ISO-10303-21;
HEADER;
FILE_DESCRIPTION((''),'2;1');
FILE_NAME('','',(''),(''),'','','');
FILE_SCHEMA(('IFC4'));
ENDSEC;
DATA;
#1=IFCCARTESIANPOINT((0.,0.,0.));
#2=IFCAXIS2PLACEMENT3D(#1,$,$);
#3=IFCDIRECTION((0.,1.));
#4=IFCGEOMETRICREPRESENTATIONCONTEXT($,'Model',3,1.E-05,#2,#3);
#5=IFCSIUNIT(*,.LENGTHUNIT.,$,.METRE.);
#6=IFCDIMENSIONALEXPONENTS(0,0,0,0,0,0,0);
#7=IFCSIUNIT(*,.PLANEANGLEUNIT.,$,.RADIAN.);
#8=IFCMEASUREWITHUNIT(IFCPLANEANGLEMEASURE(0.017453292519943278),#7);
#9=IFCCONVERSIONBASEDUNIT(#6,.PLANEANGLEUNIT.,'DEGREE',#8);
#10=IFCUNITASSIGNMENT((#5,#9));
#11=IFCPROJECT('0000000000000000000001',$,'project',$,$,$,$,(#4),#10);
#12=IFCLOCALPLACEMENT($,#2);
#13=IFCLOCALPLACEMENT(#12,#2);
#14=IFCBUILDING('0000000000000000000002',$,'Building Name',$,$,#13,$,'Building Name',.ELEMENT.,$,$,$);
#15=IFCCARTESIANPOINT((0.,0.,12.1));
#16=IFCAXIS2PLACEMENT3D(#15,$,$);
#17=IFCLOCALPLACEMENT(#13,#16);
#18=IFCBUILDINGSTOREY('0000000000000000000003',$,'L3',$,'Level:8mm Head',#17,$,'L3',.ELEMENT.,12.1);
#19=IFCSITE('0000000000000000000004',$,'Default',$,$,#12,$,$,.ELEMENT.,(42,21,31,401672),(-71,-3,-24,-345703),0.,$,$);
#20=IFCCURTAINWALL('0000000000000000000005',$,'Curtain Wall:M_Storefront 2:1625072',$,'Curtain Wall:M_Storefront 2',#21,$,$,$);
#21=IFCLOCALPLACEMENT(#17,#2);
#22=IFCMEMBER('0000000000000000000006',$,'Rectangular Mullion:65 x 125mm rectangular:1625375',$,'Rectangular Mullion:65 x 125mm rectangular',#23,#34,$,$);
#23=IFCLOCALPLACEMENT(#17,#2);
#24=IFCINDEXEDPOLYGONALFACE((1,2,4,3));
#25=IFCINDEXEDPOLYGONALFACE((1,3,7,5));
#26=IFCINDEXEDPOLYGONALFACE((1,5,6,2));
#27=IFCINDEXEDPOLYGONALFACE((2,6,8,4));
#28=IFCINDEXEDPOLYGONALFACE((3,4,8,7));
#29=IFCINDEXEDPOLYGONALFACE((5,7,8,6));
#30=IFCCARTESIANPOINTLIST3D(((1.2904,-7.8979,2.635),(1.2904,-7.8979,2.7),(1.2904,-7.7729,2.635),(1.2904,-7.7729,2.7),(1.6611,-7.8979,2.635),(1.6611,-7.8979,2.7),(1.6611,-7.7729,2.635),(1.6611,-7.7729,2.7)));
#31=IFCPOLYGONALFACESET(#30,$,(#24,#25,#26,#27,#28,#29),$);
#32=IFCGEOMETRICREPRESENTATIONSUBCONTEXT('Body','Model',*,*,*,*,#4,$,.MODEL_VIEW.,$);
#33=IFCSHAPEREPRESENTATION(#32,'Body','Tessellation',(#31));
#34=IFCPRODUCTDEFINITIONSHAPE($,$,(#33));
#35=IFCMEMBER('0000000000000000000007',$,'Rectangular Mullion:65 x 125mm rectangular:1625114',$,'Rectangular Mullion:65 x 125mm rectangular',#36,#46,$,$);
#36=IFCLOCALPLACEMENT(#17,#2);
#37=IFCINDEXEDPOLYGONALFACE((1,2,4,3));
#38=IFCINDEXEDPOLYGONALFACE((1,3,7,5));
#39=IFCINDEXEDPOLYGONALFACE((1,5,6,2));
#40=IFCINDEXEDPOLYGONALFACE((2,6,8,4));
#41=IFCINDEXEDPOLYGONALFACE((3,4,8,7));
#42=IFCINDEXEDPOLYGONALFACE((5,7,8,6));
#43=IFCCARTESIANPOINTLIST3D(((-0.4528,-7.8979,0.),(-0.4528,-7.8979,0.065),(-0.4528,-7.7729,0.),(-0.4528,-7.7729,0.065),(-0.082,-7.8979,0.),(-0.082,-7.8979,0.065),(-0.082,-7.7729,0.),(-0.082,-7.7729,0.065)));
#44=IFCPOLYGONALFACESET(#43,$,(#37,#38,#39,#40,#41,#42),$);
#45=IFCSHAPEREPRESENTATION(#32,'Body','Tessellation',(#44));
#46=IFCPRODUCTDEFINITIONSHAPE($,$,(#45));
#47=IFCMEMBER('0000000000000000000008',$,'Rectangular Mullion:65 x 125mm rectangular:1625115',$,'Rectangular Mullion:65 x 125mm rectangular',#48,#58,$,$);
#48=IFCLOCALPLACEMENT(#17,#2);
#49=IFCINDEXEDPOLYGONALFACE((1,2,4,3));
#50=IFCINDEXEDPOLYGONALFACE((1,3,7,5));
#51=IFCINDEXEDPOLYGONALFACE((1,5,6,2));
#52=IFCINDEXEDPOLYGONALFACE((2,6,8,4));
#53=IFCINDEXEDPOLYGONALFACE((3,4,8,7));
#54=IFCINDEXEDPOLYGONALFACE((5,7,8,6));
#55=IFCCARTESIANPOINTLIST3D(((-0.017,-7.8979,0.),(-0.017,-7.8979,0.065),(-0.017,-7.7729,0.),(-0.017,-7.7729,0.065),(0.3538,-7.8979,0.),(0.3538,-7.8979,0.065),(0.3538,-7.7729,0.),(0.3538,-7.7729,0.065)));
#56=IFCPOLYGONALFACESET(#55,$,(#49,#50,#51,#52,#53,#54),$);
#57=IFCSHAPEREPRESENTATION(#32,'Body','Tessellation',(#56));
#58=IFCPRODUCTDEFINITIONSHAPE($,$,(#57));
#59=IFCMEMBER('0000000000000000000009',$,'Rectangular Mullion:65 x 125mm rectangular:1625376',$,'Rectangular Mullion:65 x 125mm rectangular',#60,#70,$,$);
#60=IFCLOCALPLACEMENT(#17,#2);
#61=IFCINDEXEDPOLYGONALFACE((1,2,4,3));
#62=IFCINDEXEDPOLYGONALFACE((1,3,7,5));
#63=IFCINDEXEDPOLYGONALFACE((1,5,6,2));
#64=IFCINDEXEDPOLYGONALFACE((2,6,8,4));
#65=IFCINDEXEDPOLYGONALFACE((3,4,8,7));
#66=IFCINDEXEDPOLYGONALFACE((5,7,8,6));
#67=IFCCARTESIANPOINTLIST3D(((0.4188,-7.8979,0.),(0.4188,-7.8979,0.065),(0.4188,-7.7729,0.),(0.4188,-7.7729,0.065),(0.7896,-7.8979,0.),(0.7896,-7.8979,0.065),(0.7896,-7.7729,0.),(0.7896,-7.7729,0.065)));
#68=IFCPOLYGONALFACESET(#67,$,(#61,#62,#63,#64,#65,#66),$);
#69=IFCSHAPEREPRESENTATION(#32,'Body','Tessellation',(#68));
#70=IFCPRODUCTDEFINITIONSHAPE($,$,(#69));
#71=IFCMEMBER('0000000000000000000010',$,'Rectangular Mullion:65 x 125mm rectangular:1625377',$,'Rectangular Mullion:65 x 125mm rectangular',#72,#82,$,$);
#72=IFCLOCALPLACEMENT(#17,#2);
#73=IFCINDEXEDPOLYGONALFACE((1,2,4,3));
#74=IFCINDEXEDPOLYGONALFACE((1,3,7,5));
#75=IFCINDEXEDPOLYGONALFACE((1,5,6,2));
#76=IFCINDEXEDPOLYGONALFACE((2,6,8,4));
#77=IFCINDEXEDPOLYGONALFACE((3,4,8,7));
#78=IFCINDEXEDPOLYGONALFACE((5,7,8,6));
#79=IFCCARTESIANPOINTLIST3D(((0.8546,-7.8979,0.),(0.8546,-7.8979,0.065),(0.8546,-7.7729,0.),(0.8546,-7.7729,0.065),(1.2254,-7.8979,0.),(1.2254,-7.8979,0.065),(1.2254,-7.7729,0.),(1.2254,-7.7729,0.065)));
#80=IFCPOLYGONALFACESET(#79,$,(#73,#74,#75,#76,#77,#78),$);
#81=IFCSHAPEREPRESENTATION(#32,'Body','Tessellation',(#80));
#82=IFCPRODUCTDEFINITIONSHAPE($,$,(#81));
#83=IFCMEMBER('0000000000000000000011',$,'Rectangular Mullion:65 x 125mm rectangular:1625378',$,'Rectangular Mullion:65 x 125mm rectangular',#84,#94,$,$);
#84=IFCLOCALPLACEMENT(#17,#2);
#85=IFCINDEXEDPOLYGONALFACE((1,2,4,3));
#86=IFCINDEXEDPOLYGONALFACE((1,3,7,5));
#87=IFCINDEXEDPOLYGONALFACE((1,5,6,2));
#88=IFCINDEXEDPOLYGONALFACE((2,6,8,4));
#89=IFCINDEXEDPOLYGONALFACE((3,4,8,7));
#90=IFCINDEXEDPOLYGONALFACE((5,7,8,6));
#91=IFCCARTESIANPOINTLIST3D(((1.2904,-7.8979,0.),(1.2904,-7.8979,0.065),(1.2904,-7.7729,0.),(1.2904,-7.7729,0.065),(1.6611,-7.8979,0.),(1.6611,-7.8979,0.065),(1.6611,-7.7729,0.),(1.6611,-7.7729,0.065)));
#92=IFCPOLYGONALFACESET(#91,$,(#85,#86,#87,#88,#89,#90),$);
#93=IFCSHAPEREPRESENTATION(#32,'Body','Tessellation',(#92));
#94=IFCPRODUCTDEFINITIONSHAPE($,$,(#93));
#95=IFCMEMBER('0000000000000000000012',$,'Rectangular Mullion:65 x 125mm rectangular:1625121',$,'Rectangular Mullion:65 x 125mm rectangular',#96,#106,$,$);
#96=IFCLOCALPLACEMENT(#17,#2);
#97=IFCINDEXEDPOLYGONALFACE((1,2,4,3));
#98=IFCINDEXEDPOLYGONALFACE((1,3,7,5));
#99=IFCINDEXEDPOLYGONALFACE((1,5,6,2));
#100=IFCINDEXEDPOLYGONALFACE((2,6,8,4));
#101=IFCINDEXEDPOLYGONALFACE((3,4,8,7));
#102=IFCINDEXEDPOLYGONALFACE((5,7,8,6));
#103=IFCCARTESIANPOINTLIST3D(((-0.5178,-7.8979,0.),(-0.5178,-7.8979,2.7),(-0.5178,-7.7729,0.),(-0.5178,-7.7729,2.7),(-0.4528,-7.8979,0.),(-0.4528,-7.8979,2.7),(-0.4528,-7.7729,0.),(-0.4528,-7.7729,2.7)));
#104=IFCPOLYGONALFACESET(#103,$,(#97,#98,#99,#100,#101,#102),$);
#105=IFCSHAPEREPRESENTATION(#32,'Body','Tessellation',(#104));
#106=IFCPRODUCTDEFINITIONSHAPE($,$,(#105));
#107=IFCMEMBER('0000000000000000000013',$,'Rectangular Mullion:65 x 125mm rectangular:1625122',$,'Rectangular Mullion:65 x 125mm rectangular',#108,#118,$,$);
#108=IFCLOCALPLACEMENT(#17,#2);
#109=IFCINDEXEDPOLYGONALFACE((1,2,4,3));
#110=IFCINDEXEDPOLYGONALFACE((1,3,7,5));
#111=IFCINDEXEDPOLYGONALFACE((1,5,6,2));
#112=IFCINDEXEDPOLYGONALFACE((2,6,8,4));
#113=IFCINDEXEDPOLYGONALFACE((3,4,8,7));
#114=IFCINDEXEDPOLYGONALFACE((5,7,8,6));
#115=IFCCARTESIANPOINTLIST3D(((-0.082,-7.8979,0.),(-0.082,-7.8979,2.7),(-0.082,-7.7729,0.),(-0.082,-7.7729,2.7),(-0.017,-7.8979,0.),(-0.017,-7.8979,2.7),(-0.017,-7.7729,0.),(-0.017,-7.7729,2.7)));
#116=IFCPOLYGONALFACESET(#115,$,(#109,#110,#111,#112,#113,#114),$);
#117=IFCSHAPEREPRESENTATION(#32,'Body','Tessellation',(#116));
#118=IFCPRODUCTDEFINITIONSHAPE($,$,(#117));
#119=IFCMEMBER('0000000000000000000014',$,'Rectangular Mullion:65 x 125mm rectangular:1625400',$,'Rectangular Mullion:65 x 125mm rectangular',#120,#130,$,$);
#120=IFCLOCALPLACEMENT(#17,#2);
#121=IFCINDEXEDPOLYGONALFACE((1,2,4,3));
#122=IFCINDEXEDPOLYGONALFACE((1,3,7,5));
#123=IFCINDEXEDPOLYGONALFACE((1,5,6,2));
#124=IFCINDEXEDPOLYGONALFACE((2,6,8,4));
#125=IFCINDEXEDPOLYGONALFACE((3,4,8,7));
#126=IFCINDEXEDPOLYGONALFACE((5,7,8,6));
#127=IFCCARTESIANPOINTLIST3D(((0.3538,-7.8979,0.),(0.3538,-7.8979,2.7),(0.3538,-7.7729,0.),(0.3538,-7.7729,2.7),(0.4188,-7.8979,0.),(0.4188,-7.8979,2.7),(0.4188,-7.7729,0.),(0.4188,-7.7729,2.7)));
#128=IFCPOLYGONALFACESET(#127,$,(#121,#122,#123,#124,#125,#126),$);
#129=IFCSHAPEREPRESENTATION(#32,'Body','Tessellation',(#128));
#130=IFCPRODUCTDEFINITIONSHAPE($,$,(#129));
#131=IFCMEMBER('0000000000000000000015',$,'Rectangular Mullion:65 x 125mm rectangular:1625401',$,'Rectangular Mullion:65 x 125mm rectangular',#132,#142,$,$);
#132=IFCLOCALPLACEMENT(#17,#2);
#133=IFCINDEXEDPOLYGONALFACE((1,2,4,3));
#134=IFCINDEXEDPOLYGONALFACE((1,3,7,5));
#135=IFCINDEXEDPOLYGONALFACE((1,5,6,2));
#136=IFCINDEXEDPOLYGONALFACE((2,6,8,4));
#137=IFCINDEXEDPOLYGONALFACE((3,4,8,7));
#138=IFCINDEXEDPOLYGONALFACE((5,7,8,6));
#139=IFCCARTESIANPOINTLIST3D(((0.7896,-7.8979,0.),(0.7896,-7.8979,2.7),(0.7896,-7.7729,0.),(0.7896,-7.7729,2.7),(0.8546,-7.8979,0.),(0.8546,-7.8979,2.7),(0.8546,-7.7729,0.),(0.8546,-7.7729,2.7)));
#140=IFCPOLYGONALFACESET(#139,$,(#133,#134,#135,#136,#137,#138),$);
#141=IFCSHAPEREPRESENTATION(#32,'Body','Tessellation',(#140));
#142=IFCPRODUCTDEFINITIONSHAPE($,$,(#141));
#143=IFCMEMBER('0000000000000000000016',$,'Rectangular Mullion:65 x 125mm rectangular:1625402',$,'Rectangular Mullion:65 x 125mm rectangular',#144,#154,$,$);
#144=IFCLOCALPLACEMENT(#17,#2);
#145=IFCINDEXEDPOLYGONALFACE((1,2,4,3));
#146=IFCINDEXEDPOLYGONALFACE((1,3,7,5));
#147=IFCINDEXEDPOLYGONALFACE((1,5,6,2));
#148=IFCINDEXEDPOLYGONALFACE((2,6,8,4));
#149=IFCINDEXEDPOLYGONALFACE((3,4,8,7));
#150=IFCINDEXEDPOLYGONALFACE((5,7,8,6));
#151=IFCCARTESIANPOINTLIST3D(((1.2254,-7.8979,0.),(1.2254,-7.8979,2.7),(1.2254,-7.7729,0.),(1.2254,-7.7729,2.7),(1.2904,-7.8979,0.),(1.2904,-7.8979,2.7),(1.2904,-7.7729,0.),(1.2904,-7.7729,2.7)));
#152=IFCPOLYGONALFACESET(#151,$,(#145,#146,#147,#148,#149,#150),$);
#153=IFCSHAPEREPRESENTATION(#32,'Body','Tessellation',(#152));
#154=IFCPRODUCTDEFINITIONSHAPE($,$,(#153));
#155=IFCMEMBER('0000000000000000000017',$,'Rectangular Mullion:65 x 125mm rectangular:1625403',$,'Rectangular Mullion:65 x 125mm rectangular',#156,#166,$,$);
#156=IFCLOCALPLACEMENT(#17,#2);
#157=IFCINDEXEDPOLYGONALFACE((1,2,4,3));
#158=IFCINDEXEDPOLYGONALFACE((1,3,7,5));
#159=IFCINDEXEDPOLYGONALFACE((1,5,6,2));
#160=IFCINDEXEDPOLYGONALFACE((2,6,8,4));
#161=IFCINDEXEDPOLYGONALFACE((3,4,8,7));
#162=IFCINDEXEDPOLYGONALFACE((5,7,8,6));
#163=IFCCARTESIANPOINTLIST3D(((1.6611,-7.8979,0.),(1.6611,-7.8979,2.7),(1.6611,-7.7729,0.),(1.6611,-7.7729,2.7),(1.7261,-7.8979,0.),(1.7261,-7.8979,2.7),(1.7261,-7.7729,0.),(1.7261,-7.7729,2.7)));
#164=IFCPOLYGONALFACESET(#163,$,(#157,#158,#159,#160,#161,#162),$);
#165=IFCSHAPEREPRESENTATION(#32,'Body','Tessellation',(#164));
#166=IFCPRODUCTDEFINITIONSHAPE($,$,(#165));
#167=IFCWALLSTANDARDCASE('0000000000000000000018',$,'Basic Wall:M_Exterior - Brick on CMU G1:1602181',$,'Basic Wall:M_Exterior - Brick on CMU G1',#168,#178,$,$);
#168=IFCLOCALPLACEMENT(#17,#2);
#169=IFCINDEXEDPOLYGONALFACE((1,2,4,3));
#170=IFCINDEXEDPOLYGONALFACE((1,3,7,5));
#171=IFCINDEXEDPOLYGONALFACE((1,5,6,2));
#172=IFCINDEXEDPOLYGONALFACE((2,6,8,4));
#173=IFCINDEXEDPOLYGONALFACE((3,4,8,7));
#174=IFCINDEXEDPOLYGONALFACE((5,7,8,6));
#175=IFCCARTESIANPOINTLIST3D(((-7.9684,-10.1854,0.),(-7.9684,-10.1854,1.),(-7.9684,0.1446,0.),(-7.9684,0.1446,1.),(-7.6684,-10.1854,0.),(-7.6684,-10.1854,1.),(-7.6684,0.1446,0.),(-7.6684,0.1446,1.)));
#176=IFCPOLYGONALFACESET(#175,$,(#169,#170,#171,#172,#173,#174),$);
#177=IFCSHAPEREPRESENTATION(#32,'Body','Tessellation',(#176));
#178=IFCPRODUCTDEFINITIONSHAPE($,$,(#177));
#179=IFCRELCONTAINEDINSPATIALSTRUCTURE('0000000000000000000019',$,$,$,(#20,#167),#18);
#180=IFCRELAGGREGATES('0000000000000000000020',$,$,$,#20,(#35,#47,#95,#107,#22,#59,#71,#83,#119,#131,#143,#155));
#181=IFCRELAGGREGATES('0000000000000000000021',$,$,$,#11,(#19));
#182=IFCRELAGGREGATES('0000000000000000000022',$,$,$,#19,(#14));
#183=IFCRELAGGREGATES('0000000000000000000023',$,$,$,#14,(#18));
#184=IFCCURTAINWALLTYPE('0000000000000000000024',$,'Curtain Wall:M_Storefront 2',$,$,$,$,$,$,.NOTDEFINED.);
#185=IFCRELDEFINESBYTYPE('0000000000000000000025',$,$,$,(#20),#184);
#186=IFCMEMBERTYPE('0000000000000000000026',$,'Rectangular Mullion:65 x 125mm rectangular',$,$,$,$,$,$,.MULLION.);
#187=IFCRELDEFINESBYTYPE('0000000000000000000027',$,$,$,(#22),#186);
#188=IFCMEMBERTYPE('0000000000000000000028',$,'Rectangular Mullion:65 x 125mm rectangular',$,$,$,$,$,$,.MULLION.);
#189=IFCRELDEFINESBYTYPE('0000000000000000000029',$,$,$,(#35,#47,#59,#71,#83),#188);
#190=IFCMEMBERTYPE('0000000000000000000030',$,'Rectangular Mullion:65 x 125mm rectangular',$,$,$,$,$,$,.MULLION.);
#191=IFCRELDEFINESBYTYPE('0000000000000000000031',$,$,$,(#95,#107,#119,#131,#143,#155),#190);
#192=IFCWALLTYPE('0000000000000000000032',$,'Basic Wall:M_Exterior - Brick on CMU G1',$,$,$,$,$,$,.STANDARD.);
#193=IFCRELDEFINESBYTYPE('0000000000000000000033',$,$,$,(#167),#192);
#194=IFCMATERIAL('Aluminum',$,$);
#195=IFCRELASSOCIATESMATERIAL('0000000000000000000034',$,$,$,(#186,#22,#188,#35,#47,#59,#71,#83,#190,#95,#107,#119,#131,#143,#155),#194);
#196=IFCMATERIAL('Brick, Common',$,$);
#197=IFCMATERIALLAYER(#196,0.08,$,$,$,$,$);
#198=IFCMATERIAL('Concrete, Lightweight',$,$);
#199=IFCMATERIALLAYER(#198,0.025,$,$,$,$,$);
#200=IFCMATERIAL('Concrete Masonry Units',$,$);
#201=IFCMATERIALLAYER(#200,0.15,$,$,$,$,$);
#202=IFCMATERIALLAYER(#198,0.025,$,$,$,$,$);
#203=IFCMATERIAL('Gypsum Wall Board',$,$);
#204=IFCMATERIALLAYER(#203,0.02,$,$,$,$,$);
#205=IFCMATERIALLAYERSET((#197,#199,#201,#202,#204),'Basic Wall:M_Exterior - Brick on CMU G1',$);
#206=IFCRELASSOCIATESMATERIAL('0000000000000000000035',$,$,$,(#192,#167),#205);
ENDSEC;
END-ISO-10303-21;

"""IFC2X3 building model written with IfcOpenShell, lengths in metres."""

from ifc_helpers import new_model, entity, si_unit, converted_unit, direction, frame, frame_2d, origin, origin_2d_with_axis, place, context, subcontext, project, spatial, rectangle, extrude, source, transform, mapped, material, layer, layer_set, layer_usage, type_object, type_shapes, element, aggregate, save


model = new_model("IFC2X3")

# Units and contexts
model_context = context("Model", 3, precision=1e-05, world=origin(), true_north=direction((0.0, 1.0)))
body_context = subcontext(model_context, "Body", "Model", "MODEL_VIEW")
ifc_project = project(units=[si_unit("LENGTHUNIT", "METRE"), converted_unit("PLANEANGLEUNIT", "DEGREE", entity("IfcPlaneAngleMeasure", 0.017453292519943278), si_unit("PLANEANGLEUNIT", "RADIAN"), dimensions=[0, 0, 0, 0, 0, 0, 0])], contexts=[model_context])

# Site, building, storey
site_placement = place(None, origin())
site = spatial("IfcSite", under=ifc_project, at=site_placement, Name="Default", CompositionType="ELEMENT", RefLatitude=(42, 21, 31, 401672), RefLongitude=(-71, -3, -24, -345703), RefElevation=0.0)
building_placement = place(site_placement, origin())
building = spatial("IfcBuilding", under=site, at=building_placement, Name="Building Name", LongName="Building Name", CompositionType="ELEMENT")
storey_placement = place(building_placement, frame((0.0, 0.0, 12.1)))
storey = spatial("IfcBuildingStorey", under=building, at=storey_placement, Name="L3", ObjectType="Level:8mm Head", LongName="L3", CompositionType="ELEMENT", Elevation=12.1)

# Curtain wall, members
ifc_material_1 = material(Name="Aluminum")
curtain_wall_type_1 = type_object("IfcCurtainWallType", Name="Curtain Wall:M_Storefront 2", PredefinedType="NOTDEFINED")
curtain_wall_1_placement = place(storey_placement, frame((0.0, 0.0, -12.1)))
curtain_wall_1 = element("IfcCurtainWall", 1, at=curtain_wall_1_placement, inside=storey, type_object=curtain_wall_type_1, Name="Curtain Wall:M_Storefront 2:1625072", ObjectType="Curtain Wall:M_Storefront 2")
member_type_1 = type_object("IfcMemberType", Name="Rectangular Mullion:65 x 125mm rectangular", PredefinedType="MULLION", material=ifc_material_1)
shared_shape_1 = source(origin(), body_context, "Body", "SweptSolid", [
    extrude(rectangle(XDim=0.065, YDim=0.125, at=origin_2d_with_axis()), frame((-0.0325, 0.0, -0.3708), z_axis=(0.0, 0.0, 1.0), x_axis=(-1.0, 0.0, 0.0)), (0.0, 0.0, 1.0), 0.3708),
])
type_shapes(member_type_1, [shared_shape_1])
member_1_placement = place(curtain_wall_1_placement, frame((1.6611, -7.8354, 14.8), z_axis=(1.0, 0.0, 0.0), x_axis=(0.0, 0.0, 1.0)))
member_1 = element("IfcMember", 2, at=member_1_placement, type_object=member_type_1, material=ifc_material_1, Name="Rectangular Mullion:65 x 125mm rectangular:1625375", ObjectType="Rectangular Mullion:65 x 125mm rectangular", context=body_context, shape_type="MappedRepresentation", body=[
    mapped(shared_shape_1, transform((0.0, 0.0, 0.0), scale=1.0)),
])
member_type_2 = type_object("IfcMemberType", Name="Rectangular Mullion:65 x 125mm rectangular", PredefinedType="MULLION", material=ifc_material_1)
shared_shape_2 = source(origin(), body_context, "Body", "SweptSolid", [
    extrude(rectangle(XDim=0.065, YDim=0.125, at=origin_2d_with_axis()), frame((-0.0325, 0.0, -0.3708), z_axis=(0.0, 0.0, 1.0), x_axis=(-1.0, 0.0, 0.0)), (0.0, 0.0, 1.0), 0.3708),
])
type_shapes(member_type_2, [shared_shape_2])
member_2_placement = place(curtain_wall_1_placement, frame((-0.4528, -7.8354, 12.1), z_axis=(-1.0, 0.0, 0.0), x_axis=(0.0, 0.0, -1.0)))
member_2 = element("IfcMember", 3, at=member_2_placement, type_object=member_type_2, material=ifc_material_1, Name="Rectangular Mullion:65 x 125mm rectangular:1625114", ObjectType="Rectangular Mullion:65 x 125mm rectangular", context=body_context, shape_type="MappedRepresentation", body=[
    mapped(shared_shape_2, transform((0.0, 0.0, 0.0), scale=1.0)),
])
member_3_placement = place(curtain_wall_1_placement, frame((-0.017, -7.8354, 12.1), z_axis=(-1.0, 0.0, 0.0), x_axis=(0.0, 0.0, -1.0)))
member_3 = element("IfcMember", 4, at=member_3_placement, type_object=member_type_2, material=ifc_material_1, Name="Rectangular Mullion:65 x 125mm rectangular:1625115", ObjectType="Rectangular Mullion:65 x 125mm rectangular", context=body_context, shape_type="MappedRepresentation", body=[
    mapped(shared_shape_2, transform((0.0, 0.0, 0.0), scale=1.0)),
])
member_4_placement = place(curtain_wall_1_placement, frame((0.4188, -7.8354, 12.1), z_axis=(-1.0, 0.0, 0.0), x_axis=(0.0, 0.0, -1.0)))
member_4 = element("IfcMember", 5, at=member_4_placement, type_object=member_type_2, material=ifc_material_1, Name="Rectangular Mullion:65 x 125mm rectangular:1625376", ObjectType="Rectangular Mullion:65 x 125mm rectangular", context=body_context, shape_type="MappedRepresentation", body=[
    mapped(shared_shape_2, transform((0.0, 0.0, 0.0), scale=1.0)),
])
member_5_placement = place(curtain_wall_1_placement, frame((0.8546, -7.8354, 12.1), z_axis=(-1.0, 0.0, 0.0), x_axis=(0.0, 0.0, -1.0)))
member_5 = element("IfcMember", 6, at=member_5_placement, type_object=member_type_2, material=ifc_material_1, Name="Rectangular Mullion:65 x 125mm rectangular:1625377", ObjectType="Rectangular Mullion:65 x 125mm rectangular", context=body_context, shape_type="MappedRepresentation", body=[
    mapped(shared_shape_2, transform((0.0, 0.0, 0.0), scale=1.0)),
])
member_6_placement = place(curtain_wall_1_placement, frame((1.2904, -7.8354, 12.1), z_axis=(-1.0, 0.0, 0.0), x_axis=(0.0, 0.0, -1.0)))
member_6 = element("IfcMember", 7, at=member_6_placement, type_object=member_type_2, material=ifc_material_1, Name="Rectangular Mullion:65 x 125mm rectangular:1625378", ObjectType="Rectangular Mullion:65 x 125mm rectangular", context=body_context, shape_type="MappedRepresentation", body=[
    mapped(shared_shape_2, transform((0.0, 0.0, 0.0), scale=1.0)),
])
member_type_3 = type_object("IfcMemberType", Name="Rectangular Mullion:65 x 125mm rectangular", PredefinedType="MULLION", material=ifc_material_1)
shared_shape_3 = source(origin(), body_context, "Body", "SweptSolid", [
    extrude(rectangle(XDim=0.065, YDim=0.125, at=origin_2d_with_axis()), frame((0.0, 0.0, -2.7), z_axis=(0.0, 0.0, 1.0), x_axis=(-1.0, 0.0, 0.0)), (0.0, 0.0, 1.0), 2.7),
])
type_shapes(member_type_3, [shared_shape_3])
member_7_placement = place(curtain_wall_1_placement, frame((-0.4853, -7.8354, 12.1), z_axis=(0.0, 0.0, -1.0), x_axis=(1.0, 0.0, 0.0)))
member_7 = element("IfcMember", 8, at=member_7_placement, type_object=member_type_3, material=ifc_material_1, Name="Rectangular Mullion:65 x 125mm rectangular:1625121", ObjectType="Rectangular Mullion:65 x 125mm rectangular", context=body_context, shape_type="MappedRepresentation", body=[
    mapped(shared_shape_3, transform((0.0, 0.0, 0.0), scale=1.0)),
])
member_8_placement = place(curtain_wall_1_placement, frame((-0.0495, -7.8354, 12.1), z_axis=(0.0, 0.0, -1.0), x_axis=(1.0, 0.0, 0.0)))
member_8 = element("IfcMember", 9, at=member_8_placement, type_object=member_type_3, material=ifc_material_1, Name="Rectangular Mullion:65 x 125mm rectangular:1625122", ObjectType="Rectangular Mullion:65 x 125mm rectangular", context=body_context, shape_type="MappedRepresentation", body=[
    mapped(shared_shape_3, transform((0.0, 0.0, 0.0), scale=1.0)),
])
member_9_placement = place(curtain_wall_1_placement, frame((0.3863, -7.8354, 12.1), z_axis=(0.0, 0.0, -1.0), x_axis=(1.0, 0.0, 0.0)))
member_9 = element("IfcMember", 10, at=member_9_placement, type_object=member_type_3, material=ifc_material_1, Name="Rectangular Mullion:65 x 125mm rectangular:1625400", ObjectType="Rectangular Mullion:65 x 125mm rectangular", context=body_context, shape_type="MappedRepresentation", body=[
    mapped(shared_shape_3, transform((0.0, 0.0, 0.0), scale=1.0)),
])
member_10_placement = place(curtain_wall_1_placement, frame((0.8221, -7.8354, 12.1), z_axis=(0.0, 0.0, -1.0), x_axis=(1.0, 0.0, 0.0)))
member_10 = element("IfcMember", 11, at=member_10_placement, type_object=member_type_3, material=ifc_material_1, Name="Rectangular Mullion:65 x 125mm rectangular:1625401", ObjectType="Rectangular Mullion:65 x 125mm rectangular", context=body_context, shape_type="MappedRepresentation", body=[
    mapped(shared_shape_3, transform((0.0, 0.0, 0.0), scale=1.0)),
])
member_11_placement = place(curtain_wall_1_placement, frame((1.2579, -7.8354, 12.1), z_axis=(0.0, 0.0, -1.0), x_axis=(1.0, 0.0, 0.0)))
member_11 = element("IfcMember", 12, at=member_11_placement, type_object=member_type_3, material=ifc_material_1, Name="Rectangular Mullion:65 x 125mm rectangular:1625402", ObjectType="Rectangular Mullion:65 x 125mm rectangular", context=body_context, shape_type="MappedRepresentation", body=[
    mapped(shared_shape_3, transform((0.0, 0.0, 0.0), scale=1.0)),
])
member_12_placement = place(curtain_wall_1_placement, frame((1.6936, -7.8354, 12.1), z_axis=(0.0, 0.0, -1.0), x_axis=(1.0, 0.0, 0.0)))
member_12 = element("IfcMember", 13, at=member_12_placement, type_object=member_type_3, material=ifc_material_1, Name="Rectangular Mullion:65 x 125mm rectangular:1625403", ObjectType="Rectangular Mullion:65 x 125mm rectangular", context=body_context, shape_type="MappedRepresentation", body=[
    mapped(shared_shape_3, transform((0.0, 0.0, 0.0), scale=1.0)),
])

aggregate(curtain_wall_1, [member_2, member_3, member_7, member_8, member_1, member_4, member_5, member_6, member_9, member_10, member_11, member_12])

# Wall
ifc_material_2 = material(Name="Brick, Common")
ifc_layer_1 = layer(ifc_material_2, 0.08)
ifc_material_3 = material(Name="Concrete, Lightweight")
ifc_layer_2 = layer(ifc_material_3, 0.025)
ifc_material_4 = material(Name="Concrete Masonry Units")
ifc_layer_3 = layer(ifc_material_4, 0.15)
ifc_layer_4 = layer(ifc_material_3, 0.025)
ifc_material_5 = material(Name="Gypsum Wall Board")
ifc_layer_5 = layer(ifc_material_5, 0.02)
ifc_layer_set = layer_set([ifc_layer_1, ifc_layer_2, ifc_layer_3, ifc_layer_4, ifc_layer_5], Name="Basic Wall:M_Exterior - Brick on CMU G1")
ifc_layer_usage_1 = layer_usage(ifc_layer_set, "AXIS2", "NEGATIVE", 0.15)
wall_type = type_object("IfcWallType", Name="Basic Wall:M_Exterior - Brick on CMU G1", PredefinedType="STANDARD", material=ifc_layer_set)
wall_1_placement = place(storey_placement, frame((-7.8184, -10.1854, 0.0), z_axis=(0.0, 0.0, 1.0), x_axis=(0.0, 1.0, 0.0)))
element("IfcWallStandardCase", 14, at=wall_1_placement, inside=storey, type_object=wall_type, material=ifc_layer_usage_1, Name="Basic Wall:M_Exterior - Brick on CMU G1:1602181", ObjectType="Basic Wall:M_Exterior - Brick on CMU G1", context=body_context, shape_type="SweptSolid", body=[
    extrude(rectangle(XDim=10.33, YDim=0.3, at=frame_2d((5.165, 0.0), x_axis=(-1.0, 0.0))), origin(), (0.0, 0.0, 1.0), 1.0),
])

save(model, "model.ifc")
